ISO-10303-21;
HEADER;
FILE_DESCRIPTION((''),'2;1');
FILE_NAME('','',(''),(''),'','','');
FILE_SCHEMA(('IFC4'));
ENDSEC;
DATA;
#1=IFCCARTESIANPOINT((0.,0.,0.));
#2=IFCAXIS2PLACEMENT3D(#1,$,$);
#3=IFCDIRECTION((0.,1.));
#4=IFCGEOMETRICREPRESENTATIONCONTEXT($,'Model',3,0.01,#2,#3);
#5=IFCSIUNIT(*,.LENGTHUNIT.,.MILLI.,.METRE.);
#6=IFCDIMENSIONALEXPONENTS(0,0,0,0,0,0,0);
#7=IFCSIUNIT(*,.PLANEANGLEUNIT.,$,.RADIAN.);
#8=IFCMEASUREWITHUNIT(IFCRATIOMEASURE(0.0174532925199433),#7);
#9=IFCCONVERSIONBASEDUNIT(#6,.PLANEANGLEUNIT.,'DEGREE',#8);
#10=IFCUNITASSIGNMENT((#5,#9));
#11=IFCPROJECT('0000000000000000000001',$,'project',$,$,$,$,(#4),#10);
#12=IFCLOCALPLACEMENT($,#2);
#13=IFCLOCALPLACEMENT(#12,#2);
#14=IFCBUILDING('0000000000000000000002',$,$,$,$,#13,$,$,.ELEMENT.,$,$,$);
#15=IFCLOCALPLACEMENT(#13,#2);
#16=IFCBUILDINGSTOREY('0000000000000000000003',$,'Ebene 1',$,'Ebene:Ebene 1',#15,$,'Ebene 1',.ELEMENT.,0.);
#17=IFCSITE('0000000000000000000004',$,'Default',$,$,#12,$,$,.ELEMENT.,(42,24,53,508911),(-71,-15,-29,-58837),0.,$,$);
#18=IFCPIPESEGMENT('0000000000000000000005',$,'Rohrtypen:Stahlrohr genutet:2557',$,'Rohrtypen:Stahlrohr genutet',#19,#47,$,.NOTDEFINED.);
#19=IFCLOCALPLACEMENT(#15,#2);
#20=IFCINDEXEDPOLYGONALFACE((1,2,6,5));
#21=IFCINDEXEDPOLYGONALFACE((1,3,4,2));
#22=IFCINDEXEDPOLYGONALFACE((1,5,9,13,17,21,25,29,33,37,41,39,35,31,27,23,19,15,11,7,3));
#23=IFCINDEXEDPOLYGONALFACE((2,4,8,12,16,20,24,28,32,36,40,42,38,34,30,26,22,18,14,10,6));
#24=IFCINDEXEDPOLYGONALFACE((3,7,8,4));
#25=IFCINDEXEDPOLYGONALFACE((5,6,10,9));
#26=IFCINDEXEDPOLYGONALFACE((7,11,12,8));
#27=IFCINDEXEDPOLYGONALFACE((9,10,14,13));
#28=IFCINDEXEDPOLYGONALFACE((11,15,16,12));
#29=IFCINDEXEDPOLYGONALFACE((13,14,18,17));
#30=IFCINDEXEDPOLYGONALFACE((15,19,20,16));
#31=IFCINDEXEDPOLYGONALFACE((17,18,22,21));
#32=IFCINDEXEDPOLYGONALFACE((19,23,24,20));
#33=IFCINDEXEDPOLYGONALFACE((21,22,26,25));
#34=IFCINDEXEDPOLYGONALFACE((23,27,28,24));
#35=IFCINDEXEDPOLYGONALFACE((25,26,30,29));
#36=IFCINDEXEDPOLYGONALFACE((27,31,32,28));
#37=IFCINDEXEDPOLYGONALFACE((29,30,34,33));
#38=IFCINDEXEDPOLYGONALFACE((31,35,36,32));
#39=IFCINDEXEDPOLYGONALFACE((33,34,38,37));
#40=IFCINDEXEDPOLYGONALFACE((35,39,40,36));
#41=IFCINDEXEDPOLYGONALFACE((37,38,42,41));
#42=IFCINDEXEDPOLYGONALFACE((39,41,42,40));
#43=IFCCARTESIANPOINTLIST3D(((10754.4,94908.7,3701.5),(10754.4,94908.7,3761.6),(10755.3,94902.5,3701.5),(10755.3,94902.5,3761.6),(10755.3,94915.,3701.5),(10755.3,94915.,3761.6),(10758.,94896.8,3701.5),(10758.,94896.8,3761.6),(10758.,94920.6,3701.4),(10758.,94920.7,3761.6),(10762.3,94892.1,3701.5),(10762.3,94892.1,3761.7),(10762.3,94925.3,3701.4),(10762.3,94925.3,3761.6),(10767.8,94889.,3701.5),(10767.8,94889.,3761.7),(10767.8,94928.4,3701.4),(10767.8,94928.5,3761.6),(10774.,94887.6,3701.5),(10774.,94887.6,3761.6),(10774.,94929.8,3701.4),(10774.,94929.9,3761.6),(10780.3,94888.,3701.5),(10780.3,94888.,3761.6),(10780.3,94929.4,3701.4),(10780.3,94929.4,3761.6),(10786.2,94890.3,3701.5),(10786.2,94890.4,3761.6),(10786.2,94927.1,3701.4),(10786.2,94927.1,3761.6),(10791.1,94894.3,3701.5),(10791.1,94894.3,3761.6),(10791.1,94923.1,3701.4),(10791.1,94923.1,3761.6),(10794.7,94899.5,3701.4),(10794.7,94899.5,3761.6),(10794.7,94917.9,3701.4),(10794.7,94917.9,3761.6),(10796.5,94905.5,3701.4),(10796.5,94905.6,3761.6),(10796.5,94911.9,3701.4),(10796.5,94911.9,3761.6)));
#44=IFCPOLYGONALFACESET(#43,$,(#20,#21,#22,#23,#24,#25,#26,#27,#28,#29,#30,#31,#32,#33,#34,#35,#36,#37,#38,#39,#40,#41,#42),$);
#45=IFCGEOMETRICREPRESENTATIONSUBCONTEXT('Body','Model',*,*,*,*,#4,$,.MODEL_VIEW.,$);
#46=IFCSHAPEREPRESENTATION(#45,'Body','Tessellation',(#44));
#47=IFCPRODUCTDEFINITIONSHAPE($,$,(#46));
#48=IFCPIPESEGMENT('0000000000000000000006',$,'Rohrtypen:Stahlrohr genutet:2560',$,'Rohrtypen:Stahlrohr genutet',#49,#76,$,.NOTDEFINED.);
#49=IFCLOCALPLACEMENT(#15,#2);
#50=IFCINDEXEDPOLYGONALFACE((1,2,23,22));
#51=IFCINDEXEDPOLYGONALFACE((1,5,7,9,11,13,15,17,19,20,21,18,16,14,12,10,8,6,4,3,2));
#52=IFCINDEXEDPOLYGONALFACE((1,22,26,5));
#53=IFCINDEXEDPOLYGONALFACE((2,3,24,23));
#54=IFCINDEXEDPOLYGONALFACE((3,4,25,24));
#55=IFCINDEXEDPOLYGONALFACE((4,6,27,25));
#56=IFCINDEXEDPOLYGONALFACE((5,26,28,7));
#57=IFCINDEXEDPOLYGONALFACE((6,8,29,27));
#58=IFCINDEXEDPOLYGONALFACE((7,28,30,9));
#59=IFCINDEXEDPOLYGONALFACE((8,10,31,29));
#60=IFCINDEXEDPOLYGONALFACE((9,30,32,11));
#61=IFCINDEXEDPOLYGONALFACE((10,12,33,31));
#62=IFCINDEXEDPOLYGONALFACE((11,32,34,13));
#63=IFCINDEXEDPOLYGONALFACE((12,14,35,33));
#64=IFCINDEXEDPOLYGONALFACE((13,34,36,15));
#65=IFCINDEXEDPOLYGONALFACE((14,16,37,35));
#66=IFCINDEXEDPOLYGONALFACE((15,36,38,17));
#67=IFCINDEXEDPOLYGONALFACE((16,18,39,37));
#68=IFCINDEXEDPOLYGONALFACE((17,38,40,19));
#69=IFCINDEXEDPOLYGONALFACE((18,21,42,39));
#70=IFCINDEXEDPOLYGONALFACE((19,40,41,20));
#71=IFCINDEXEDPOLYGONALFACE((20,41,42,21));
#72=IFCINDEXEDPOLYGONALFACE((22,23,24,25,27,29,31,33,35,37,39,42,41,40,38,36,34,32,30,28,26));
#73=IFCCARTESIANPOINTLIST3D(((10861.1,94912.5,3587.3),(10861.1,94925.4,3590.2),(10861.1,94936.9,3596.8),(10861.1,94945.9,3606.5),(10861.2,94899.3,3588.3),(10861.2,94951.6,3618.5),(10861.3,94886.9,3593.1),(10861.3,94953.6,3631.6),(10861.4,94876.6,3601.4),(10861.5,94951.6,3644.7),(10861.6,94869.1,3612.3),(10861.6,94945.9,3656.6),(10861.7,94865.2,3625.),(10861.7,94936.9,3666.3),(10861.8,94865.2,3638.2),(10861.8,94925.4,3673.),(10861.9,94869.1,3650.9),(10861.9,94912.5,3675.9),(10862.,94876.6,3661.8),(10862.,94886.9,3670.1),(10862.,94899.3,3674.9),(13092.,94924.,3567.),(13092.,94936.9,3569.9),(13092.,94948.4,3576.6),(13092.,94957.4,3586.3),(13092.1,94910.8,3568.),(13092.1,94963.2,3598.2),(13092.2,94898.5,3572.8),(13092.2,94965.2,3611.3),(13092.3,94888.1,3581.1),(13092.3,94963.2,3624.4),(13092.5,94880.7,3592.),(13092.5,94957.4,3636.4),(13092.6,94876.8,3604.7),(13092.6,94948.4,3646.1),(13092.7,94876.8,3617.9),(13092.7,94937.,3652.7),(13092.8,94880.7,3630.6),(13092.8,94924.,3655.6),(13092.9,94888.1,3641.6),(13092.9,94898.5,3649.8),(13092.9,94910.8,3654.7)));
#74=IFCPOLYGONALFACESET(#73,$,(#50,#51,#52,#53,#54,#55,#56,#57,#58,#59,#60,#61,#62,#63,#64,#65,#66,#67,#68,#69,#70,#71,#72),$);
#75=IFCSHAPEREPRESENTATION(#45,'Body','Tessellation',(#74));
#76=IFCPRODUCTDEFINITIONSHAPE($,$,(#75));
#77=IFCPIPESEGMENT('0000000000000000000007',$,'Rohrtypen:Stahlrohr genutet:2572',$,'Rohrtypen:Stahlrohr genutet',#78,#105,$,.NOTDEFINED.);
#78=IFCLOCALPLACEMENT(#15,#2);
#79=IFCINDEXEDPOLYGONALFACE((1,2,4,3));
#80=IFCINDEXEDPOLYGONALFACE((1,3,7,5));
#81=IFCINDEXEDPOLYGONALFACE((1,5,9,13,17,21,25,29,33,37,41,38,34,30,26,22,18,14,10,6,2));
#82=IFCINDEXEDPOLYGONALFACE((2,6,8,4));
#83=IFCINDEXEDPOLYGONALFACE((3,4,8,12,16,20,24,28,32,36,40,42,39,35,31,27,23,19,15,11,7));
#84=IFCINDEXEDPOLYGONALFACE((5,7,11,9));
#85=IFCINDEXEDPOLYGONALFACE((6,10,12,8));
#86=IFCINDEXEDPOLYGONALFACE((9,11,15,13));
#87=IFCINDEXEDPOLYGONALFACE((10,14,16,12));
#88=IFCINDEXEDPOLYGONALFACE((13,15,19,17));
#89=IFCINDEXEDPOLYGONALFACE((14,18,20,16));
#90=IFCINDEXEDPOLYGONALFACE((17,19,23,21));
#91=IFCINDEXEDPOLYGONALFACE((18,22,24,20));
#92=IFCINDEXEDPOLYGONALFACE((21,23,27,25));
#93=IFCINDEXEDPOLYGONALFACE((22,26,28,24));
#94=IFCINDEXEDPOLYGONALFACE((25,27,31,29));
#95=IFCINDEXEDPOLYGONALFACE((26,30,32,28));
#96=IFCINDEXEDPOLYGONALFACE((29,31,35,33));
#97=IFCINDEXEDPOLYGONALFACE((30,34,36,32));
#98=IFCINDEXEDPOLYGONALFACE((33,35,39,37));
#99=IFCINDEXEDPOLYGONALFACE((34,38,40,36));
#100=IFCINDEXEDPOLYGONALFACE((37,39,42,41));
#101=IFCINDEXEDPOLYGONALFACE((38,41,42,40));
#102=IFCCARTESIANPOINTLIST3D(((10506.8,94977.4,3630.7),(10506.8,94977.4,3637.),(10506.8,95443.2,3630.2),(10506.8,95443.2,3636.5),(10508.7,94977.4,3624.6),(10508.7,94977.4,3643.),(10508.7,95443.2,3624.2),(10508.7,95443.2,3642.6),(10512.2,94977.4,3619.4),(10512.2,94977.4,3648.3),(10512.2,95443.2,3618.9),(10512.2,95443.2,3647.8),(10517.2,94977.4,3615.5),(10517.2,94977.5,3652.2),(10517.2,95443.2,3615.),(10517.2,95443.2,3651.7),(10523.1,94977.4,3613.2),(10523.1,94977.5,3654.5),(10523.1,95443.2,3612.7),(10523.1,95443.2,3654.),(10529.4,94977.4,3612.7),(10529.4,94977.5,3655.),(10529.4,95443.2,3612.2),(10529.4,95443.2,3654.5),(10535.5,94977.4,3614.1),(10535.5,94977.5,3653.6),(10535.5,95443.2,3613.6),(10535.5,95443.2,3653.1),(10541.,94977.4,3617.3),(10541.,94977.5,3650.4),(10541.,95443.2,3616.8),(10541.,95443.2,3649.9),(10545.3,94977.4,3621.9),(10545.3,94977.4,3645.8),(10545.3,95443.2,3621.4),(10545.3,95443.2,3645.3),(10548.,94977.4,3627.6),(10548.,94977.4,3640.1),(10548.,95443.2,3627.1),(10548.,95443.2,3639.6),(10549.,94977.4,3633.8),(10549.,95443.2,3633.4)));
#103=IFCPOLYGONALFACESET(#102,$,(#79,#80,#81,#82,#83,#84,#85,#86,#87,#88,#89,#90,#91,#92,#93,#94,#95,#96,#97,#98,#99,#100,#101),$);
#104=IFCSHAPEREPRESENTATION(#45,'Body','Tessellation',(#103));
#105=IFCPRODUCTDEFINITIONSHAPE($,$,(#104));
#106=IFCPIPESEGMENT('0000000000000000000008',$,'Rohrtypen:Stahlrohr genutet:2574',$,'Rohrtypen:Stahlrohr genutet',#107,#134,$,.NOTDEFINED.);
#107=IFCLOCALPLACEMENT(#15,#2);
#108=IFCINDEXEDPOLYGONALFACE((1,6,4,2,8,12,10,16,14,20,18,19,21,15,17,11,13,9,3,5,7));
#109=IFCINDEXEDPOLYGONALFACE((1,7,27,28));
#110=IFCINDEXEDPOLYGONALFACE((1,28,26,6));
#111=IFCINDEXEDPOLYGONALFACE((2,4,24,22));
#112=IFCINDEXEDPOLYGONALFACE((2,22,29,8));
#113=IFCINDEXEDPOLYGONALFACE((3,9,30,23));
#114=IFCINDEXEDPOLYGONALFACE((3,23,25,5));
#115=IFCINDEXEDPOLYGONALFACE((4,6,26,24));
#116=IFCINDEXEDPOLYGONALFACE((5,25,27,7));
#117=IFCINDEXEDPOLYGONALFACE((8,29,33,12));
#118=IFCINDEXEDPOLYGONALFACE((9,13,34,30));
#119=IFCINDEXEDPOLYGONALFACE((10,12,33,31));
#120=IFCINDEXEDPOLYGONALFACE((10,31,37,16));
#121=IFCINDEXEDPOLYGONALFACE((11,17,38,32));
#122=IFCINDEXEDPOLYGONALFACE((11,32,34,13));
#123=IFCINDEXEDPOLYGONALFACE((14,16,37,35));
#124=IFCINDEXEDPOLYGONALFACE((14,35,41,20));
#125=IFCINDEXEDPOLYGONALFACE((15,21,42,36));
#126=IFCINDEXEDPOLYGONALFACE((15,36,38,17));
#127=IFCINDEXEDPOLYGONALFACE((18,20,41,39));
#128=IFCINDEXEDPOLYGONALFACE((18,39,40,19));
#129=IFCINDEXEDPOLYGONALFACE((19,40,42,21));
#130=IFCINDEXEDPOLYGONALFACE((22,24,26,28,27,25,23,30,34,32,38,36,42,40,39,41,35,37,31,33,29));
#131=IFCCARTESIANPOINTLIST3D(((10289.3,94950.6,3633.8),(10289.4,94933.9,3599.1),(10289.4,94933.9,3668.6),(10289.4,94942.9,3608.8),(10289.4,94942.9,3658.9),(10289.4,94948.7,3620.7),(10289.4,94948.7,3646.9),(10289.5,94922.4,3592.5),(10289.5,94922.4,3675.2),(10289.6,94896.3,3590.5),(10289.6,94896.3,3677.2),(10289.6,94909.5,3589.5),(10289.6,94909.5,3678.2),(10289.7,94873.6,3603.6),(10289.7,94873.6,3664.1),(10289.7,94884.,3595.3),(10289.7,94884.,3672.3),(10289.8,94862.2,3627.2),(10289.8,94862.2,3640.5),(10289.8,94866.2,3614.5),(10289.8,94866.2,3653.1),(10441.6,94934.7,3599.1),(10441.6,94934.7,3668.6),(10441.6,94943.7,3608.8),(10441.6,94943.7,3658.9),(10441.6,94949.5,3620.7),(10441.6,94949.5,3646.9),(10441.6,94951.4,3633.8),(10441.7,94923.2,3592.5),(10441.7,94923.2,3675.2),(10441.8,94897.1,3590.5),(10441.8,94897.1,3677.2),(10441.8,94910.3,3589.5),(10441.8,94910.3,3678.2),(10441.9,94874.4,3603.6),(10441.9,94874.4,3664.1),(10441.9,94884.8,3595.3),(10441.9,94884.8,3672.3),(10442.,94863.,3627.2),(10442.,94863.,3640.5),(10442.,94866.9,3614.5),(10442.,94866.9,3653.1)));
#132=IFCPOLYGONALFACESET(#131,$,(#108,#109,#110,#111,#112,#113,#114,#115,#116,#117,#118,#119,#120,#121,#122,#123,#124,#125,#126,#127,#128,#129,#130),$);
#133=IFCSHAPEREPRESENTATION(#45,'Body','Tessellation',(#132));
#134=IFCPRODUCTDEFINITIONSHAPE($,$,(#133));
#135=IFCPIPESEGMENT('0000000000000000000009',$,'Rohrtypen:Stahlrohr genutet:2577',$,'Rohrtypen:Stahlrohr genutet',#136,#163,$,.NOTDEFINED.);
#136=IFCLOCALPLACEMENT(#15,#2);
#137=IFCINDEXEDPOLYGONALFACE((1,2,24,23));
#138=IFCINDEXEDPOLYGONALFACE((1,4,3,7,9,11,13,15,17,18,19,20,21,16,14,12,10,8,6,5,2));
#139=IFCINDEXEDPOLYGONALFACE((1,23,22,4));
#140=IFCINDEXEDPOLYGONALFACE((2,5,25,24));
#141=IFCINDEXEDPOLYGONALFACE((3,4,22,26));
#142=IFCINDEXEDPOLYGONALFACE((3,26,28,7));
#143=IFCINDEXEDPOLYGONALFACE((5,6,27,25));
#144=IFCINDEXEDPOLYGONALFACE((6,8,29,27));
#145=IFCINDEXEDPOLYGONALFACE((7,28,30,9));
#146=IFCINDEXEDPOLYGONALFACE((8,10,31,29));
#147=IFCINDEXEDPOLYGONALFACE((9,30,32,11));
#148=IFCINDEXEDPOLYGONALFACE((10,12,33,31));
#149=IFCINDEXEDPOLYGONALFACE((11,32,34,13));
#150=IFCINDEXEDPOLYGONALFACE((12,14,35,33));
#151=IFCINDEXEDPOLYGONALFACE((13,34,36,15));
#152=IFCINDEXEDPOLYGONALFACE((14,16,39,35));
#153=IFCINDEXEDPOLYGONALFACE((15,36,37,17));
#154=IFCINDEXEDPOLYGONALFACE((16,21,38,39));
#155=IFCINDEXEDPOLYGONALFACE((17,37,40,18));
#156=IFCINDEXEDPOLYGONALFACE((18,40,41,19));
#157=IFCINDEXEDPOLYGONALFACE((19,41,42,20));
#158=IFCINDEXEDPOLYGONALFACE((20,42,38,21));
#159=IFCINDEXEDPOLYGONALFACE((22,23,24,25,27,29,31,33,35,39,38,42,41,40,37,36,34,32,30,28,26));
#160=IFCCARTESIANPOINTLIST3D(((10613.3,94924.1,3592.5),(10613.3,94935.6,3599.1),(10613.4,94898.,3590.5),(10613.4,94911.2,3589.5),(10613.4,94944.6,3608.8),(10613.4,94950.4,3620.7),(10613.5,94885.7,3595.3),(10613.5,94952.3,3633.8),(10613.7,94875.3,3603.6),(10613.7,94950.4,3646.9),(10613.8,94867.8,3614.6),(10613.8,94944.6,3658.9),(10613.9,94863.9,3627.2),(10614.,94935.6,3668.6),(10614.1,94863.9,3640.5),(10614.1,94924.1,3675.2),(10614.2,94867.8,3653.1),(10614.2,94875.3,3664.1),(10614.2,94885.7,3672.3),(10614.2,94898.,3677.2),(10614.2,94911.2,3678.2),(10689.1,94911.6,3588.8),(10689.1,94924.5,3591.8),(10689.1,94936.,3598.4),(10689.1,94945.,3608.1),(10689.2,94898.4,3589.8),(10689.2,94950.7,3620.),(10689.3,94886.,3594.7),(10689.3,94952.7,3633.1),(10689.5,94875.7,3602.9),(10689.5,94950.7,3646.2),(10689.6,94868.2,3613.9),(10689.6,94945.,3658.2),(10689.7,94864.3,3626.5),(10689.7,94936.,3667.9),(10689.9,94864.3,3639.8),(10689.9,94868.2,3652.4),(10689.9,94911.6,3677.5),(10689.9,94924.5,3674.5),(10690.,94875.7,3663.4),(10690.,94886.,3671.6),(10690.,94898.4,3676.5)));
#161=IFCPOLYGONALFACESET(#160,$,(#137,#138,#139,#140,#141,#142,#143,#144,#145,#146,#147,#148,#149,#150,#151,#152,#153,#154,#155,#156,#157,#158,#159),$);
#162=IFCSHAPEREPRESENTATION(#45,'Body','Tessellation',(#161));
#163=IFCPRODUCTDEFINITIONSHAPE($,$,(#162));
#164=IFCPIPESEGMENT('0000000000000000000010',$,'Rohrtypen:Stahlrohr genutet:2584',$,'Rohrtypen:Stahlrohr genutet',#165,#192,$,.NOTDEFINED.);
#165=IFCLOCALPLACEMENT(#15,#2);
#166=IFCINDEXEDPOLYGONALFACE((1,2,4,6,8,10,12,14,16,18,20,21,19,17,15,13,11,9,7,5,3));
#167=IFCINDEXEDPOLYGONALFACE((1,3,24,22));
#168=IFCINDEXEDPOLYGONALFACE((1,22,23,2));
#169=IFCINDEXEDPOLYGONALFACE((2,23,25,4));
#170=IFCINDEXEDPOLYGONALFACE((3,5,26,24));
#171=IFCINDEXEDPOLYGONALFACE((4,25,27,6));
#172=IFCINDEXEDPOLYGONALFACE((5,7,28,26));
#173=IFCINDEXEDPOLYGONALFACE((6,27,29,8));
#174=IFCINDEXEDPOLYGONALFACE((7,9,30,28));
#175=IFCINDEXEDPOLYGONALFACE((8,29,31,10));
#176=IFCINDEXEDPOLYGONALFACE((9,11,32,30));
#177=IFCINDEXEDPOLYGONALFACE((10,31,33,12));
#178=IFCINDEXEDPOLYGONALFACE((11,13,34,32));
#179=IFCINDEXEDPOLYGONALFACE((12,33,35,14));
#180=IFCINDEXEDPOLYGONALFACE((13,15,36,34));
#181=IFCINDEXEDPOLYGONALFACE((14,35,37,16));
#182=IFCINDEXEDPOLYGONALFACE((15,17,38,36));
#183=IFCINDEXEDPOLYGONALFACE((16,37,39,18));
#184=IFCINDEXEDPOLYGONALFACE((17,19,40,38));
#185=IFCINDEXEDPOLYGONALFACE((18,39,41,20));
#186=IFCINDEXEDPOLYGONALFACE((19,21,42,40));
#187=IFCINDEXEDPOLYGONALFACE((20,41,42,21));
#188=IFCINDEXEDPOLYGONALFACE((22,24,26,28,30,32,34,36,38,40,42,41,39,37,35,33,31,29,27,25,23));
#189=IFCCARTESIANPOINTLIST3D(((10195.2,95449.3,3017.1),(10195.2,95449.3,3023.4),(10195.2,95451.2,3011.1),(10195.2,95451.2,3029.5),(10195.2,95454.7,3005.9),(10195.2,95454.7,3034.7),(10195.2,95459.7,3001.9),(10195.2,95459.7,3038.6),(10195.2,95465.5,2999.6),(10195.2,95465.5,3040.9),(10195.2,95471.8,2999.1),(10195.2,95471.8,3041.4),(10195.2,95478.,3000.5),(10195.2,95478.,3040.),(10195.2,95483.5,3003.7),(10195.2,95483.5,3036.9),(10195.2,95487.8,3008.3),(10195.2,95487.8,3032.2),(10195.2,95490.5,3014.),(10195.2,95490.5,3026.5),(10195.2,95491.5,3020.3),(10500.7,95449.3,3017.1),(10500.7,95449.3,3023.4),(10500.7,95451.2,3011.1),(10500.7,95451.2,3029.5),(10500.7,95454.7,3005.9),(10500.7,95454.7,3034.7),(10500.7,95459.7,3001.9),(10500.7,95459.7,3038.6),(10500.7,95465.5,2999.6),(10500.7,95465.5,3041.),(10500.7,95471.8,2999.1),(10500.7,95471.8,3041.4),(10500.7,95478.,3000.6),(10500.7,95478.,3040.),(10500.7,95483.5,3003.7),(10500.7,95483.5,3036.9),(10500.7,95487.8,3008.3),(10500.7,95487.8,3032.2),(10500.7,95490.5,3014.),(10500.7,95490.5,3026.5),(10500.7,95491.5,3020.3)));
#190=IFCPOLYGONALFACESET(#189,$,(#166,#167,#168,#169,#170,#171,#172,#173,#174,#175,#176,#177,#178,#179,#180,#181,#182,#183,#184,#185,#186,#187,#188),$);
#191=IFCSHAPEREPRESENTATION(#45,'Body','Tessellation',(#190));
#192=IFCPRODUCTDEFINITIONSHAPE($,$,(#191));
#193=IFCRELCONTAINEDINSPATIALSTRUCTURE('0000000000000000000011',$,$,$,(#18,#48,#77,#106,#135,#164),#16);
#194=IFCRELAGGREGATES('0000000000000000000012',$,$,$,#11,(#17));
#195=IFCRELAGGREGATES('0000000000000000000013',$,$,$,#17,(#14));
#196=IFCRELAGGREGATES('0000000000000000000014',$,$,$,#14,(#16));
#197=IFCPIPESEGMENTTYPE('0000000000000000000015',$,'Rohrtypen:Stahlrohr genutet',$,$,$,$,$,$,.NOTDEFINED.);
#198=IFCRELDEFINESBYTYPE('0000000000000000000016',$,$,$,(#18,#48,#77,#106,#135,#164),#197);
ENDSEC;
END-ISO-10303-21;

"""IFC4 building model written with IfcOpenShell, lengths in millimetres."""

from ifc_helpers import new_model, entity, si_unit, converted_unit, direction, frame, frame_2d, origin, origin_2d_with_axis, place, context, subcontext, project, spatial, circle, extrude, type_object, element, save


model = new_model("IFC4")

# Units and contexts
model_context = context("Model", 3, precision=0.01, world=origin(), true_north=direction((0.0, 1.0)))
body_context = subcontext(model_context, "Body", "Model", "MODEL_VIEW")
ifc_project = project(units=[si_unit("LENGTHUNIT", "METRE", prefix="MILLI"), converted_unit("PLANEANGLEUNIT", "DEGREE", entity("IfcRatioMeasure", 0.0174532925199433), si_unit("PLANEANGLEUNIT", "RADIAN"), dimensions=[0, 0, 0, 0, 0, 0, 0])], contexts=[model_context])

# Site, building, storey
site_placement = place(None, origin())
site = spatial("IfcSite", under=ifc_project, at=site_placement, Name="Default", CompositionType="ELEMENT", RefLatitude=(42, 24, 53, 508911), RefLongitude=(-71, -15, -29, -58837), RefElevation=0.0)
building_placement = place(site_placement, origin())
building = spatial("IfcBuilding", under=site, at=building_placement, CompositionType="ELEMENT")
storey_placement = place(building_placement, origin())
storey = spatial("IfcBuildingStorey", under=building, at=storey_placement, Name="Ebene 1", ObjectType="Ebene:Ebene 1", LongName="Ebene 1", CompositionType="ELEMENT", Elevation=0.0)

# Pipe segments
pipe_segment_type = type_object("IfcPipeSegmentType", Name="Rohrtypen:Stahlrohr genutet", PredefinedType="NOTDEFINED")
pipe_segment_1_placement = place(storey_placement, frame((10752.8, 94885.9, 3701.4)))
element("IfcPipeSegment", 1, at=pipe_segment_1_placement, inside=storey, type_object=pipe_segment_type, Name="Rohrtypen:Stahlrohr genutet:2557", ObjectType="Rohrtypen:Stahlrohr genutet", PredefinedType="NOTDEFINED", context=body_context, shape_type="SweptSolid", body=[
    extrude(circle(Radius=21.2, at=frame_2d((0.0, 0.0), x_axis=(1.0, 0.0))), frame((22.8, 22.8, 0.0), z_axis=(0.000178, 0.000272, 1.0), x_axis=(-1.0, 0.0, 0.000178)), (0.0, 0.0, 1.0), 60.2),
])
pipe_segment_2_placement = place(storey_placement, frame((10859.5, 94863.1, 3565.3)))
element("IfcPipeSegment", 2, at=pipe_segment_2_placement, inside=storey, type_object=pipe_segment_type, Name="Rohrtypen:Stahlrohr genutet:2560", ObjectType="Rohrtypen:Stahlrohr genutet", PredefinedType="NOTDEFINED", context=body_context, shape_type="SweptSolid", body=[
    extrude(circle(Radius=44.5, at=frame_2d((0.0, 0.0), x_axis=(1.0, 0.0))), frame((2.1, 46.0, 66.3), z_axis=(0.999945, 0.005177, -0.009082), x_axis=(-0.005177, 0.999987, 0.0)), (0.0, 0.0, 1.0), 2231.0),
])
pipe_segment_3_placement = place(storey_placement, frame((10505.0, 94977.4, 3610.6)))
element("IfcPipeSegment", 3, at=pipe_segment_3_placement, inside=storey, type_object=pipe_segment_type, Name="Rohrtypen:Stahlrohr genutet:2572", ObjectType="Rohrtypen:Stahlrohr genutet", PredefinedType="NOTDEFINED", context=body_context, shape_type="SweptSolid", body=[
    extrude(circle(Radius=21.2, at=origin_2d_with_axis()), frame((22.8, 0.0, 23.3), z_axis=(0.0, 0.999999, -0.00103), x_axis=(1.0, 0.0, 0.0)), (0.0, 0.0, 1.0), 465.8),
])
pipe_segment_4_placement = place(storey_placement, frame((10287.7, 94860.2, 3587.8)))
element("IfcPipeSegment", 4, at=pipe_segment_4_placement, inside=storey, type_object=pipe_segment_type, Name="Rohrtypen:Stahlrohr genutet:2574", ObjectType="Rohrtypen:Stahlrohr genutet", PredefinedType="NOTDEFINED", context=body_context, shape_type="SweptSolid", body=[
    extrude(circle(Radius=44.5, at=frame_2d((0.0, 0.0), x_axis=(1.0, 0.0))), frame((1.8, 46.0, 46.0), z_axis=(0.999987, 0.005177, 0.0), x_axis=(-0.005177, 0.999987, 0.0)), (0.0, 0.0, 1.0), 152.2),
])
pipe_segment_5_placement = place(storey_placement, frame((10611.7, 94861.8, 3587.1)))
element("IfcPipeSegment", 5, at=pipe_segment_5_placement, inside=storey, type_object=pipe_segment_type, Name="Rohrtypen:Stahlrohr genutet:2577", ObjectType="Rohrtypen:Stahlrohr genutet", PredefinedType="NOTDEFINED", context=body_context, shape_type="SweptSolid", body=[
    extrude(circle(Radius=44.5, at=origin_2d_with_axis()), frame((2.1, 46.0, 46.7), z_axis=(0.999945, 0.005177, -0.009082), x_axis=(-0.005177, 0.999987, 0.0)), (0.0, 0.0, 1.0), 75.8),
])
pipe_segment_6_placement = place(storey_placement, frame((10195.2, 95447.5, 2997.5)))
element("IfcPipeSegment", 6, at=pipe_segment_6_placement, inside=storey, type_object=pipe_segment_type, Name="Rohrtypen:Stahlrohr genutet:2584", ObjectType="Rohrtypen:Stahlrohr genutet", PredefinedType="NOTDEFINED", context=body_context, shape_type="SweptSolid", body=[
    extrude(circle(Radius=21.2, at=origin_2d_with_axis()), frame((0.0, 22.8, 22.8), z_axis=(1.0, 0.0, 0.000022), x_axis=(0.0, 1.0, 0.0)), (0.0, 0.0, 1.0), 305.5),
])

save(model, "model.ifc")
